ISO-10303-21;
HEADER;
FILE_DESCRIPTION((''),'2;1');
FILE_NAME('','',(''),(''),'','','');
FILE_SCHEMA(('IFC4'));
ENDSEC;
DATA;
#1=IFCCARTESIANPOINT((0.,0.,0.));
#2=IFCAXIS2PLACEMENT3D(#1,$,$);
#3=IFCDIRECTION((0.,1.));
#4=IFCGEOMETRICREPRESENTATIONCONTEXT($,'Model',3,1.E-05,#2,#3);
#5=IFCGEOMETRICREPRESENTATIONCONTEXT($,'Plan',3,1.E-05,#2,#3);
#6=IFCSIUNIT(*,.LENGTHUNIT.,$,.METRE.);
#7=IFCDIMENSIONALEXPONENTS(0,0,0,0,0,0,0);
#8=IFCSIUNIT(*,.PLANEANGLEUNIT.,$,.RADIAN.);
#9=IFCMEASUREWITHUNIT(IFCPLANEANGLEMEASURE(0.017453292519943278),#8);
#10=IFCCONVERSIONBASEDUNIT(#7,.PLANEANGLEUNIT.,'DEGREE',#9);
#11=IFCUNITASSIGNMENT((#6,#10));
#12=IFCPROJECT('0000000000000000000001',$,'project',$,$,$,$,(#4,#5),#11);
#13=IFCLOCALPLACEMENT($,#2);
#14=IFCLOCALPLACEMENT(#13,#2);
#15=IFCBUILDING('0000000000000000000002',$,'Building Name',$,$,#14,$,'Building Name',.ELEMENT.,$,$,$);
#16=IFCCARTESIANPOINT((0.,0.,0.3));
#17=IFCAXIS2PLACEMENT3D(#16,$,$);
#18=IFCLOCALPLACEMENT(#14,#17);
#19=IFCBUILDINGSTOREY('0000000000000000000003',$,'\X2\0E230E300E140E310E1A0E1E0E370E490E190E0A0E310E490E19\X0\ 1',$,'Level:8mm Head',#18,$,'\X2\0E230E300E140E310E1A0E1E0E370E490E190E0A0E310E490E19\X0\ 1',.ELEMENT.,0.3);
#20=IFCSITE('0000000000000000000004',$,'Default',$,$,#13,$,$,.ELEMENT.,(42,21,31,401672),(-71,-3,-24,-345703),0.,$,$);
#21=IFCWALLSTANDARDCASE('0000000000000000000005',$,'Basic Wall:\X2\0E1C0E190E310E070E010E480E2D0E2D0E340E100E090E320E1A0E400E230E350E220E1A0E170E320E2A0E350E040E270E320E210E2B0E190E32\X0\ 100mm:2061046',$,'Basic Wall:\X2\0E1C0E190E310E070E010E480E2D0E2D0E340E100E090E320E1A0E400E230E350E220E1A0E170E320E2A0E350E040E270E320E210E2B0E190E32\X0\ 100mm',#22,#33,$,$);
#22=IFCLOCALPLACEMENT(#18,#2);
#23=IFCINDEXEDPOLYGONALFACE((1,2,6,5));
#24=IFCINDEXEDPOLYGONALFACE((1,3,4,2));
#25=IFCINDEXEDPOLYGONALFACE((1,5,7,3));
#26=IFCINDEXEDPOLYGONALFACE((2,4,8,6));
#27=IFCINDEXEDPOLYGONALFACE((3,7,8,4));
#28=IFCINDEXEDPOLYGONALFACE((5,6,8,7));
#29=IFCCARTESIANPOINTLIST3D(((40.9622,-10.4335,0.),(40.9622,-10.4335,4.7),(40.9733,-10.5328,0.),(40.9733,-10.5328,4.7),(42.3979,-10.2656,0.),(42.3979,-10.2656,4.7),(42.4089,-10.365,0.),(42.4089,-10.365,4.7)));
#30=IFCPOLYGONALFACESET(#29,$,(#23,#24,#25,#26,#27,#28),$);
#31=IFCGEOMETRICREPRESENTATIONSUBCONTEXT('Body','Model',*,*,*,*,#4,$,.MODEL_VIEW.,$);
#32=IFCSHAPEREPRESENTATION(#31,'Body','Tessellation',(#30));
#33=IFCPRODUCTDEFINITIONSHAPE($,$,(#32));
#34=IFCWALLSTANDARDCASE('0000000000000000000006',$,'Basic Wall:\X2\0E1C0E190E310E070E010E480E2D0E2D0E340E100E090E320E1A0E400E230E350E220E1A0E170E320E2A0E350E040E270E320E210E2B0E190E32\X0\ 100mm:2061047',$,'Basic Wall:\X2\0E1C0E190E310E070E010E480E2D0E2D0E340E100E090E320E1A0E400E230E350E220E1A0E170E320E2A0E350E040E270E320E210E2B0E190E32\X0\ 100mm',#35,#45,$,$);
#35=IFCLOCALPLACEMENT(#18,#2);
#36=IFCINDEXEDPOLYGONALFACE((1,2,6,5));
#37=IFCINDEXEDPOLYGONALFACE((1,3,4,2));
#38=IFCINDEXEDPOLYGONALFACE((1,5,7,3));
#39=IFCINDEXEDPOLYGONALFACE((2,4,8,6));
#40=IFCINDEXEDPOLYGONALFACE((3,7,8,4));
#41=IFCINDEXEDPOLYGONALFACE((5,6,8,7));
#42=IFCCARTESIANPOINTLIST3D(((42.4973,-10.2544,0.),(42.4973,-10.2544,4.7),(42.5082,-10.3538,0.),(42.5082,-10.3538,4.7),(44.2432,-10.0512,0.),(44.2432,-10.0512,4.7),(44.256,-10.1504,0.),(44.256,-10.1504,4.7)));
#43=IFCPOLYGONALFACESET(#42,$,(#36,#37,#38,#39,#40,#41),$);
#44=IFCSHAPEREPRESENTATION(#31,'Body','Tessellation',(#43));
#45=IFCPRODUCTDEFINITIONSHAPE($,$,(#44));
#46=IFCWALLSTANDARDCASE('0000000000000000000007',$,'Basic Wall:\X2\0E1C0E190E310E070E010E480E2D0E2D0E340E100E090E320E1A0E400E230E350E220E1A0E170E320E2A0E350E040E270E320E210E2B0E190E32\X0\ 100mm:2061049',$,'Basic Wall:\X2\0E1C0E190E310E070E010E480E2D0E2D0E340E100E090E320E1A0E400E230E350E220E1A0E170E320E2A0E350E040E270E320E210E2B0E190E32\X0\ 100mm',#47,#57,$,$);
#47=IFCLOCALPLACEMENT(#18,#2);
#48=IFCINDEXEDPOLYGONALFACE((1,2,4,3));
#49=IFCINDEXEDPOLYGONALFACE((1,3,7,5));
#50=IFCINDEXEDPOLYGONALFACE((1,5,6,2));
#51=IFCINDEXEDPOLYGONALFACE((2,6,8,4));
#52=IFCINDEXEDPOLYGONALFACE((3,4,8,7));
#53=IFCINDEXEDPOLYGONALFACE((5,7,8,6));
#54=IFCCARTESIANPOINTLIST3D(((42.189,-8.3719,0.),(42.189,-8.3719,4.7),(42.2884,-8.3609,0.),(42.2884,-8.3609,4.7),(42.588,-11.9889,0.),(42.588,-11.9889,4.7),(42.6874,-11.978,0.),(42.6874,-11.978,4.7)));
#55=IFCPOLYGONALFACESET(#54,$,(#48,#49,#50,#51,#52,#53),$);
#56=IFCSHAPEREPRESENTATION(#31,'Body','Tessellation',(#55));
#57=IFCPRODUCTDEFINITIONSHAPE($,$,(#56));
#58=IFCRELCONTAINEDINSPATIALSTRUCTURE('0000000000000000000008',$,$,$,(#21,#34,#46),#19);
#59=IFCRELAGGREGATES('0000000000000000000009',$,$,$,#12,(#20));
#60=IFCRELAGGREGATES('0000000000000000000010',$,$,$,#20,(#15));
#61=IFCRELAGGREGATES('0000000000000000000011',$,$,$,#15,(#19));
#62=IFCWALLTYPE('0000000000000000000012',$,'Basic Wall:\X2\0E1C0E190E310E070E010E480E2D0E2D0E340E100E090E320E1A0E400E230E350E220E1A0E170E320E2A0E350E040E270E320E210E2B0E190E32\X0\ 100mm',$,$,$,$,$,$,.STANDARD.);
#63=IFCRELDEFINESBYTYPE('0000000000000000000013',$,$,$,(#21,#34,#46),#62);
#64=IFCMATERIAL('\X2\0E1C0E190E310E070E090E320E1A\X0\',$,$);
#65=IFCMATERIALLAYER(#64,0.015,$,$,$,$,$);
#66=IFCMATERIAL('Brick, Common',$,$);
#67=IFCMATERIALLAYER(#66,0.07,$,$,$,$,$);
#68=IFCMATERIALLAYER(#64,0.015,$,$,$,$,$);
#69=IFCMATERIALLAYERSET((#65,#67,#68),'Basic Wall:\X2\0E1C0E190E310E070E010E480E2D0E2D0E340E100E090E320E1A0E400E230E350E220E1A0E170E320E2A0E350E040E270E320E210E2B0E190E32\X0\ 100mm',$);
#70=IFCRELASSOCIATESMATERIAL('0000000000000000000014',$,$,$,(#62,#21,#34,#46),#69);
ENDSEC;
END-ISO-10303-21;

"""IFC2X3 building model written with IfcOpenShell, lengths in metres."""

from ifc_helpers import new_model, entity, si_unit, converted_unit, direction, frame, frame_2d, origin, place, context, subcontext, project, spatial, polyline, rectangle, outline, extrude, clip, halfspace, material, layer, layer_set, layer_usage, type_object, element, save


model = new_model("IFC2X3")

# Units and contexts
model_context = context("Model", 3, precision=1e-05, world=origin(), true_north=direction((0.0, 1.0)))
plan_context = context("Plan", 3, precision=1e-05, world=origin(), true_north=direction((0.0, 1.0)))
body_context = subcontext(model_context, "Body", "Model", "MODEL_VIEW")
ifc_project = project(units=[si_unit("LENGTHUNIT", "METRE"), converted_unit("PLANEANGLEUNIT", "DEGREE", entity("IfcPlaneAngleMeasure", 0.017453292519943278), si_unit("PLANEANGLEUNIT", "RADIAN"), dimensions=[0, 0, 0, 0, 0, 0, 0])], contexts=[model_context, plan_context])

# Site, building, storey
site_placement = place(None, origin())
site = spatial("IfcSite", under=ifc_project, at=site_placement, Name="Default", CompositionType="ELEMENT", RefLatitude=(42, 21, 31, 401672), RefLongitude=(-71, -3, -24, -345703), RefElevation=0.0)
building_placement = place(site_placement, origin())
building = spatial("IfcBuilding", under=site, at=building_placement, Name="Building Name", LongName="Building Name", CompositionType="ELEMENT")
storey_placement = place(building_placement, frame((0.0, 0.0, 0.3)))
storey = spatial("IfcBuildingStorey", under=building, at=storey_placement, Name="ระดับพื้นชั้น 1", ObjectType="Level:8mm Head", LongName="ระดับพื้นชั้น 1", CompositionType="ELEMENT", Elevation=0.3)

# Shared definitions
ifc_material_1 = material(Name="ผนังฉาบ")
ifc_layer_1 = layer(ifc_material_1, 0.015)
ifc_material_2 = material(Name="Brick, Common")
ifc_layer_2 = layer(ifc_material_2, 0.07)
ifc_layer_3 = layer(ifc_material_1, 0.015)
ifc_layer_set = layer_set([ifc_layer_1, ifc_layer_2, ifc_layer_3], Name="Basic Wall:ผนังก่ออิฐฉาบเรียบทาสีความหนา 100mm")
wall_type = type_object("IfcWallType", Name="Basic Wall:ผนังก่ออิฐฉาบเรียบทาสีความหนา 100mm", PredefinedType="STANDARD", material=ifc_layer_set)

# Walls
ifc_layer_usage_1 = layer_usage(ifc_layer_set, "AXIS2", "POSITIVE", -0.05)
wall_1_placement = place(storey_placement, frame((40.9675, -10.4832, 0.0), z_axis=(0.0, 0.0, 1.0), x_axis=(0.993236, 0.116115, 0.0)))
element("IfcWallStandardCase", 1, at=wall_1_placement, inside=storey, type_object=wall_type, material=ifc_layer_usage_1, Name="Basic Wall:ผนังก่ออิฐฉาบเรียบทาสีความหนา 100mm:2061046", ObjectType="Basic Wall:ผนังก่ออิฐฉาบเรียบทาสีความหนา 100mm", context=body_context, shape_type="Clipping", body=[
    clip(extrude(outline(polyline([(1.4453, -0.05), (1.4459, 0.05), (0.0004, 0.05), (0.0, -0.05), (1.4453, -0.05)])), origin(), (0.0, 0.0, 1.0), 4.7), halfspace(frame((0.0, 0.0, -0.15)), True)),
])
ifc_layer_usage_2 = layer_usage(ifc_layer_set, "AXIS2", "POSITIVE", -0.05)
wall_2_placement = place(storey_placement, frame((42.5024, -10.3041, 0.0), z_axis=(0.0, 0.0, 1.0), x_axis=(0.993294, 0.115614, 0.0)))
element("IfcWallStandardCase", 2, at=wall_2_placement, inside=storey, type_object=wall_type, material=ifc_layer_usage_2, Name="Basic Wall:ผนังก่ออิฐฉาบเรียบทาสีความหนา 100mm:2061047", ObjectType="Basic Wall:ผนังก่ออิฐฉาบเรียบทาสีความหนา 100mm", context=body_context, shape_type="Clipping", body=[
    clip(extrude(outline(polyline([(1.7596, -0.05), (1.7583, 0.05), (0.0006, 0.05), (0.0, -0.05), (1.7596, -0.05)])), origin(), (0.0, 0.0, 1.0), 4.7), halfspace(frame((0.0, 0.0, -0.15)), True)),
])
ifc_layer_usage_3 = layer_usage(ifc_layer_set, "AXIS2", "NEGATIVE", 0.05)
wall_3_placement = place(storey_placement, frame((42.6377, -11.9835, 0.0), z_axis=(0.0, 0.0, 1.0), x_axis=(-0.10965, 0.99397, 0.0)))
element("IfcWallStandardCase", 3, at=wall_3_placement, inside=storey, type_object=wall_type, material=ifc_layer_usage_3, Name="Basic Wall:ผนังก่ออิฐฉาบเรียบทาสีความหนา 100mm:2061049", ObjectType="Basic Wall:ผนังก่ออิฐฉาบเรียบทาสีความหนา 100mm", context=body_context, shape_type="Clipping", body=[
    clip(extrude(rectangle(XDim=3.639, YDim=0.1, at=frame_2d((1.8195, 0.0), x_axis=(-1.0, 0.0))), origin(), (0.0, 0.0, 1.0), 4.7), halfspace(frame((0.0, 0.0, -0.15)), True)),
])

save(model, "model.ifc")
